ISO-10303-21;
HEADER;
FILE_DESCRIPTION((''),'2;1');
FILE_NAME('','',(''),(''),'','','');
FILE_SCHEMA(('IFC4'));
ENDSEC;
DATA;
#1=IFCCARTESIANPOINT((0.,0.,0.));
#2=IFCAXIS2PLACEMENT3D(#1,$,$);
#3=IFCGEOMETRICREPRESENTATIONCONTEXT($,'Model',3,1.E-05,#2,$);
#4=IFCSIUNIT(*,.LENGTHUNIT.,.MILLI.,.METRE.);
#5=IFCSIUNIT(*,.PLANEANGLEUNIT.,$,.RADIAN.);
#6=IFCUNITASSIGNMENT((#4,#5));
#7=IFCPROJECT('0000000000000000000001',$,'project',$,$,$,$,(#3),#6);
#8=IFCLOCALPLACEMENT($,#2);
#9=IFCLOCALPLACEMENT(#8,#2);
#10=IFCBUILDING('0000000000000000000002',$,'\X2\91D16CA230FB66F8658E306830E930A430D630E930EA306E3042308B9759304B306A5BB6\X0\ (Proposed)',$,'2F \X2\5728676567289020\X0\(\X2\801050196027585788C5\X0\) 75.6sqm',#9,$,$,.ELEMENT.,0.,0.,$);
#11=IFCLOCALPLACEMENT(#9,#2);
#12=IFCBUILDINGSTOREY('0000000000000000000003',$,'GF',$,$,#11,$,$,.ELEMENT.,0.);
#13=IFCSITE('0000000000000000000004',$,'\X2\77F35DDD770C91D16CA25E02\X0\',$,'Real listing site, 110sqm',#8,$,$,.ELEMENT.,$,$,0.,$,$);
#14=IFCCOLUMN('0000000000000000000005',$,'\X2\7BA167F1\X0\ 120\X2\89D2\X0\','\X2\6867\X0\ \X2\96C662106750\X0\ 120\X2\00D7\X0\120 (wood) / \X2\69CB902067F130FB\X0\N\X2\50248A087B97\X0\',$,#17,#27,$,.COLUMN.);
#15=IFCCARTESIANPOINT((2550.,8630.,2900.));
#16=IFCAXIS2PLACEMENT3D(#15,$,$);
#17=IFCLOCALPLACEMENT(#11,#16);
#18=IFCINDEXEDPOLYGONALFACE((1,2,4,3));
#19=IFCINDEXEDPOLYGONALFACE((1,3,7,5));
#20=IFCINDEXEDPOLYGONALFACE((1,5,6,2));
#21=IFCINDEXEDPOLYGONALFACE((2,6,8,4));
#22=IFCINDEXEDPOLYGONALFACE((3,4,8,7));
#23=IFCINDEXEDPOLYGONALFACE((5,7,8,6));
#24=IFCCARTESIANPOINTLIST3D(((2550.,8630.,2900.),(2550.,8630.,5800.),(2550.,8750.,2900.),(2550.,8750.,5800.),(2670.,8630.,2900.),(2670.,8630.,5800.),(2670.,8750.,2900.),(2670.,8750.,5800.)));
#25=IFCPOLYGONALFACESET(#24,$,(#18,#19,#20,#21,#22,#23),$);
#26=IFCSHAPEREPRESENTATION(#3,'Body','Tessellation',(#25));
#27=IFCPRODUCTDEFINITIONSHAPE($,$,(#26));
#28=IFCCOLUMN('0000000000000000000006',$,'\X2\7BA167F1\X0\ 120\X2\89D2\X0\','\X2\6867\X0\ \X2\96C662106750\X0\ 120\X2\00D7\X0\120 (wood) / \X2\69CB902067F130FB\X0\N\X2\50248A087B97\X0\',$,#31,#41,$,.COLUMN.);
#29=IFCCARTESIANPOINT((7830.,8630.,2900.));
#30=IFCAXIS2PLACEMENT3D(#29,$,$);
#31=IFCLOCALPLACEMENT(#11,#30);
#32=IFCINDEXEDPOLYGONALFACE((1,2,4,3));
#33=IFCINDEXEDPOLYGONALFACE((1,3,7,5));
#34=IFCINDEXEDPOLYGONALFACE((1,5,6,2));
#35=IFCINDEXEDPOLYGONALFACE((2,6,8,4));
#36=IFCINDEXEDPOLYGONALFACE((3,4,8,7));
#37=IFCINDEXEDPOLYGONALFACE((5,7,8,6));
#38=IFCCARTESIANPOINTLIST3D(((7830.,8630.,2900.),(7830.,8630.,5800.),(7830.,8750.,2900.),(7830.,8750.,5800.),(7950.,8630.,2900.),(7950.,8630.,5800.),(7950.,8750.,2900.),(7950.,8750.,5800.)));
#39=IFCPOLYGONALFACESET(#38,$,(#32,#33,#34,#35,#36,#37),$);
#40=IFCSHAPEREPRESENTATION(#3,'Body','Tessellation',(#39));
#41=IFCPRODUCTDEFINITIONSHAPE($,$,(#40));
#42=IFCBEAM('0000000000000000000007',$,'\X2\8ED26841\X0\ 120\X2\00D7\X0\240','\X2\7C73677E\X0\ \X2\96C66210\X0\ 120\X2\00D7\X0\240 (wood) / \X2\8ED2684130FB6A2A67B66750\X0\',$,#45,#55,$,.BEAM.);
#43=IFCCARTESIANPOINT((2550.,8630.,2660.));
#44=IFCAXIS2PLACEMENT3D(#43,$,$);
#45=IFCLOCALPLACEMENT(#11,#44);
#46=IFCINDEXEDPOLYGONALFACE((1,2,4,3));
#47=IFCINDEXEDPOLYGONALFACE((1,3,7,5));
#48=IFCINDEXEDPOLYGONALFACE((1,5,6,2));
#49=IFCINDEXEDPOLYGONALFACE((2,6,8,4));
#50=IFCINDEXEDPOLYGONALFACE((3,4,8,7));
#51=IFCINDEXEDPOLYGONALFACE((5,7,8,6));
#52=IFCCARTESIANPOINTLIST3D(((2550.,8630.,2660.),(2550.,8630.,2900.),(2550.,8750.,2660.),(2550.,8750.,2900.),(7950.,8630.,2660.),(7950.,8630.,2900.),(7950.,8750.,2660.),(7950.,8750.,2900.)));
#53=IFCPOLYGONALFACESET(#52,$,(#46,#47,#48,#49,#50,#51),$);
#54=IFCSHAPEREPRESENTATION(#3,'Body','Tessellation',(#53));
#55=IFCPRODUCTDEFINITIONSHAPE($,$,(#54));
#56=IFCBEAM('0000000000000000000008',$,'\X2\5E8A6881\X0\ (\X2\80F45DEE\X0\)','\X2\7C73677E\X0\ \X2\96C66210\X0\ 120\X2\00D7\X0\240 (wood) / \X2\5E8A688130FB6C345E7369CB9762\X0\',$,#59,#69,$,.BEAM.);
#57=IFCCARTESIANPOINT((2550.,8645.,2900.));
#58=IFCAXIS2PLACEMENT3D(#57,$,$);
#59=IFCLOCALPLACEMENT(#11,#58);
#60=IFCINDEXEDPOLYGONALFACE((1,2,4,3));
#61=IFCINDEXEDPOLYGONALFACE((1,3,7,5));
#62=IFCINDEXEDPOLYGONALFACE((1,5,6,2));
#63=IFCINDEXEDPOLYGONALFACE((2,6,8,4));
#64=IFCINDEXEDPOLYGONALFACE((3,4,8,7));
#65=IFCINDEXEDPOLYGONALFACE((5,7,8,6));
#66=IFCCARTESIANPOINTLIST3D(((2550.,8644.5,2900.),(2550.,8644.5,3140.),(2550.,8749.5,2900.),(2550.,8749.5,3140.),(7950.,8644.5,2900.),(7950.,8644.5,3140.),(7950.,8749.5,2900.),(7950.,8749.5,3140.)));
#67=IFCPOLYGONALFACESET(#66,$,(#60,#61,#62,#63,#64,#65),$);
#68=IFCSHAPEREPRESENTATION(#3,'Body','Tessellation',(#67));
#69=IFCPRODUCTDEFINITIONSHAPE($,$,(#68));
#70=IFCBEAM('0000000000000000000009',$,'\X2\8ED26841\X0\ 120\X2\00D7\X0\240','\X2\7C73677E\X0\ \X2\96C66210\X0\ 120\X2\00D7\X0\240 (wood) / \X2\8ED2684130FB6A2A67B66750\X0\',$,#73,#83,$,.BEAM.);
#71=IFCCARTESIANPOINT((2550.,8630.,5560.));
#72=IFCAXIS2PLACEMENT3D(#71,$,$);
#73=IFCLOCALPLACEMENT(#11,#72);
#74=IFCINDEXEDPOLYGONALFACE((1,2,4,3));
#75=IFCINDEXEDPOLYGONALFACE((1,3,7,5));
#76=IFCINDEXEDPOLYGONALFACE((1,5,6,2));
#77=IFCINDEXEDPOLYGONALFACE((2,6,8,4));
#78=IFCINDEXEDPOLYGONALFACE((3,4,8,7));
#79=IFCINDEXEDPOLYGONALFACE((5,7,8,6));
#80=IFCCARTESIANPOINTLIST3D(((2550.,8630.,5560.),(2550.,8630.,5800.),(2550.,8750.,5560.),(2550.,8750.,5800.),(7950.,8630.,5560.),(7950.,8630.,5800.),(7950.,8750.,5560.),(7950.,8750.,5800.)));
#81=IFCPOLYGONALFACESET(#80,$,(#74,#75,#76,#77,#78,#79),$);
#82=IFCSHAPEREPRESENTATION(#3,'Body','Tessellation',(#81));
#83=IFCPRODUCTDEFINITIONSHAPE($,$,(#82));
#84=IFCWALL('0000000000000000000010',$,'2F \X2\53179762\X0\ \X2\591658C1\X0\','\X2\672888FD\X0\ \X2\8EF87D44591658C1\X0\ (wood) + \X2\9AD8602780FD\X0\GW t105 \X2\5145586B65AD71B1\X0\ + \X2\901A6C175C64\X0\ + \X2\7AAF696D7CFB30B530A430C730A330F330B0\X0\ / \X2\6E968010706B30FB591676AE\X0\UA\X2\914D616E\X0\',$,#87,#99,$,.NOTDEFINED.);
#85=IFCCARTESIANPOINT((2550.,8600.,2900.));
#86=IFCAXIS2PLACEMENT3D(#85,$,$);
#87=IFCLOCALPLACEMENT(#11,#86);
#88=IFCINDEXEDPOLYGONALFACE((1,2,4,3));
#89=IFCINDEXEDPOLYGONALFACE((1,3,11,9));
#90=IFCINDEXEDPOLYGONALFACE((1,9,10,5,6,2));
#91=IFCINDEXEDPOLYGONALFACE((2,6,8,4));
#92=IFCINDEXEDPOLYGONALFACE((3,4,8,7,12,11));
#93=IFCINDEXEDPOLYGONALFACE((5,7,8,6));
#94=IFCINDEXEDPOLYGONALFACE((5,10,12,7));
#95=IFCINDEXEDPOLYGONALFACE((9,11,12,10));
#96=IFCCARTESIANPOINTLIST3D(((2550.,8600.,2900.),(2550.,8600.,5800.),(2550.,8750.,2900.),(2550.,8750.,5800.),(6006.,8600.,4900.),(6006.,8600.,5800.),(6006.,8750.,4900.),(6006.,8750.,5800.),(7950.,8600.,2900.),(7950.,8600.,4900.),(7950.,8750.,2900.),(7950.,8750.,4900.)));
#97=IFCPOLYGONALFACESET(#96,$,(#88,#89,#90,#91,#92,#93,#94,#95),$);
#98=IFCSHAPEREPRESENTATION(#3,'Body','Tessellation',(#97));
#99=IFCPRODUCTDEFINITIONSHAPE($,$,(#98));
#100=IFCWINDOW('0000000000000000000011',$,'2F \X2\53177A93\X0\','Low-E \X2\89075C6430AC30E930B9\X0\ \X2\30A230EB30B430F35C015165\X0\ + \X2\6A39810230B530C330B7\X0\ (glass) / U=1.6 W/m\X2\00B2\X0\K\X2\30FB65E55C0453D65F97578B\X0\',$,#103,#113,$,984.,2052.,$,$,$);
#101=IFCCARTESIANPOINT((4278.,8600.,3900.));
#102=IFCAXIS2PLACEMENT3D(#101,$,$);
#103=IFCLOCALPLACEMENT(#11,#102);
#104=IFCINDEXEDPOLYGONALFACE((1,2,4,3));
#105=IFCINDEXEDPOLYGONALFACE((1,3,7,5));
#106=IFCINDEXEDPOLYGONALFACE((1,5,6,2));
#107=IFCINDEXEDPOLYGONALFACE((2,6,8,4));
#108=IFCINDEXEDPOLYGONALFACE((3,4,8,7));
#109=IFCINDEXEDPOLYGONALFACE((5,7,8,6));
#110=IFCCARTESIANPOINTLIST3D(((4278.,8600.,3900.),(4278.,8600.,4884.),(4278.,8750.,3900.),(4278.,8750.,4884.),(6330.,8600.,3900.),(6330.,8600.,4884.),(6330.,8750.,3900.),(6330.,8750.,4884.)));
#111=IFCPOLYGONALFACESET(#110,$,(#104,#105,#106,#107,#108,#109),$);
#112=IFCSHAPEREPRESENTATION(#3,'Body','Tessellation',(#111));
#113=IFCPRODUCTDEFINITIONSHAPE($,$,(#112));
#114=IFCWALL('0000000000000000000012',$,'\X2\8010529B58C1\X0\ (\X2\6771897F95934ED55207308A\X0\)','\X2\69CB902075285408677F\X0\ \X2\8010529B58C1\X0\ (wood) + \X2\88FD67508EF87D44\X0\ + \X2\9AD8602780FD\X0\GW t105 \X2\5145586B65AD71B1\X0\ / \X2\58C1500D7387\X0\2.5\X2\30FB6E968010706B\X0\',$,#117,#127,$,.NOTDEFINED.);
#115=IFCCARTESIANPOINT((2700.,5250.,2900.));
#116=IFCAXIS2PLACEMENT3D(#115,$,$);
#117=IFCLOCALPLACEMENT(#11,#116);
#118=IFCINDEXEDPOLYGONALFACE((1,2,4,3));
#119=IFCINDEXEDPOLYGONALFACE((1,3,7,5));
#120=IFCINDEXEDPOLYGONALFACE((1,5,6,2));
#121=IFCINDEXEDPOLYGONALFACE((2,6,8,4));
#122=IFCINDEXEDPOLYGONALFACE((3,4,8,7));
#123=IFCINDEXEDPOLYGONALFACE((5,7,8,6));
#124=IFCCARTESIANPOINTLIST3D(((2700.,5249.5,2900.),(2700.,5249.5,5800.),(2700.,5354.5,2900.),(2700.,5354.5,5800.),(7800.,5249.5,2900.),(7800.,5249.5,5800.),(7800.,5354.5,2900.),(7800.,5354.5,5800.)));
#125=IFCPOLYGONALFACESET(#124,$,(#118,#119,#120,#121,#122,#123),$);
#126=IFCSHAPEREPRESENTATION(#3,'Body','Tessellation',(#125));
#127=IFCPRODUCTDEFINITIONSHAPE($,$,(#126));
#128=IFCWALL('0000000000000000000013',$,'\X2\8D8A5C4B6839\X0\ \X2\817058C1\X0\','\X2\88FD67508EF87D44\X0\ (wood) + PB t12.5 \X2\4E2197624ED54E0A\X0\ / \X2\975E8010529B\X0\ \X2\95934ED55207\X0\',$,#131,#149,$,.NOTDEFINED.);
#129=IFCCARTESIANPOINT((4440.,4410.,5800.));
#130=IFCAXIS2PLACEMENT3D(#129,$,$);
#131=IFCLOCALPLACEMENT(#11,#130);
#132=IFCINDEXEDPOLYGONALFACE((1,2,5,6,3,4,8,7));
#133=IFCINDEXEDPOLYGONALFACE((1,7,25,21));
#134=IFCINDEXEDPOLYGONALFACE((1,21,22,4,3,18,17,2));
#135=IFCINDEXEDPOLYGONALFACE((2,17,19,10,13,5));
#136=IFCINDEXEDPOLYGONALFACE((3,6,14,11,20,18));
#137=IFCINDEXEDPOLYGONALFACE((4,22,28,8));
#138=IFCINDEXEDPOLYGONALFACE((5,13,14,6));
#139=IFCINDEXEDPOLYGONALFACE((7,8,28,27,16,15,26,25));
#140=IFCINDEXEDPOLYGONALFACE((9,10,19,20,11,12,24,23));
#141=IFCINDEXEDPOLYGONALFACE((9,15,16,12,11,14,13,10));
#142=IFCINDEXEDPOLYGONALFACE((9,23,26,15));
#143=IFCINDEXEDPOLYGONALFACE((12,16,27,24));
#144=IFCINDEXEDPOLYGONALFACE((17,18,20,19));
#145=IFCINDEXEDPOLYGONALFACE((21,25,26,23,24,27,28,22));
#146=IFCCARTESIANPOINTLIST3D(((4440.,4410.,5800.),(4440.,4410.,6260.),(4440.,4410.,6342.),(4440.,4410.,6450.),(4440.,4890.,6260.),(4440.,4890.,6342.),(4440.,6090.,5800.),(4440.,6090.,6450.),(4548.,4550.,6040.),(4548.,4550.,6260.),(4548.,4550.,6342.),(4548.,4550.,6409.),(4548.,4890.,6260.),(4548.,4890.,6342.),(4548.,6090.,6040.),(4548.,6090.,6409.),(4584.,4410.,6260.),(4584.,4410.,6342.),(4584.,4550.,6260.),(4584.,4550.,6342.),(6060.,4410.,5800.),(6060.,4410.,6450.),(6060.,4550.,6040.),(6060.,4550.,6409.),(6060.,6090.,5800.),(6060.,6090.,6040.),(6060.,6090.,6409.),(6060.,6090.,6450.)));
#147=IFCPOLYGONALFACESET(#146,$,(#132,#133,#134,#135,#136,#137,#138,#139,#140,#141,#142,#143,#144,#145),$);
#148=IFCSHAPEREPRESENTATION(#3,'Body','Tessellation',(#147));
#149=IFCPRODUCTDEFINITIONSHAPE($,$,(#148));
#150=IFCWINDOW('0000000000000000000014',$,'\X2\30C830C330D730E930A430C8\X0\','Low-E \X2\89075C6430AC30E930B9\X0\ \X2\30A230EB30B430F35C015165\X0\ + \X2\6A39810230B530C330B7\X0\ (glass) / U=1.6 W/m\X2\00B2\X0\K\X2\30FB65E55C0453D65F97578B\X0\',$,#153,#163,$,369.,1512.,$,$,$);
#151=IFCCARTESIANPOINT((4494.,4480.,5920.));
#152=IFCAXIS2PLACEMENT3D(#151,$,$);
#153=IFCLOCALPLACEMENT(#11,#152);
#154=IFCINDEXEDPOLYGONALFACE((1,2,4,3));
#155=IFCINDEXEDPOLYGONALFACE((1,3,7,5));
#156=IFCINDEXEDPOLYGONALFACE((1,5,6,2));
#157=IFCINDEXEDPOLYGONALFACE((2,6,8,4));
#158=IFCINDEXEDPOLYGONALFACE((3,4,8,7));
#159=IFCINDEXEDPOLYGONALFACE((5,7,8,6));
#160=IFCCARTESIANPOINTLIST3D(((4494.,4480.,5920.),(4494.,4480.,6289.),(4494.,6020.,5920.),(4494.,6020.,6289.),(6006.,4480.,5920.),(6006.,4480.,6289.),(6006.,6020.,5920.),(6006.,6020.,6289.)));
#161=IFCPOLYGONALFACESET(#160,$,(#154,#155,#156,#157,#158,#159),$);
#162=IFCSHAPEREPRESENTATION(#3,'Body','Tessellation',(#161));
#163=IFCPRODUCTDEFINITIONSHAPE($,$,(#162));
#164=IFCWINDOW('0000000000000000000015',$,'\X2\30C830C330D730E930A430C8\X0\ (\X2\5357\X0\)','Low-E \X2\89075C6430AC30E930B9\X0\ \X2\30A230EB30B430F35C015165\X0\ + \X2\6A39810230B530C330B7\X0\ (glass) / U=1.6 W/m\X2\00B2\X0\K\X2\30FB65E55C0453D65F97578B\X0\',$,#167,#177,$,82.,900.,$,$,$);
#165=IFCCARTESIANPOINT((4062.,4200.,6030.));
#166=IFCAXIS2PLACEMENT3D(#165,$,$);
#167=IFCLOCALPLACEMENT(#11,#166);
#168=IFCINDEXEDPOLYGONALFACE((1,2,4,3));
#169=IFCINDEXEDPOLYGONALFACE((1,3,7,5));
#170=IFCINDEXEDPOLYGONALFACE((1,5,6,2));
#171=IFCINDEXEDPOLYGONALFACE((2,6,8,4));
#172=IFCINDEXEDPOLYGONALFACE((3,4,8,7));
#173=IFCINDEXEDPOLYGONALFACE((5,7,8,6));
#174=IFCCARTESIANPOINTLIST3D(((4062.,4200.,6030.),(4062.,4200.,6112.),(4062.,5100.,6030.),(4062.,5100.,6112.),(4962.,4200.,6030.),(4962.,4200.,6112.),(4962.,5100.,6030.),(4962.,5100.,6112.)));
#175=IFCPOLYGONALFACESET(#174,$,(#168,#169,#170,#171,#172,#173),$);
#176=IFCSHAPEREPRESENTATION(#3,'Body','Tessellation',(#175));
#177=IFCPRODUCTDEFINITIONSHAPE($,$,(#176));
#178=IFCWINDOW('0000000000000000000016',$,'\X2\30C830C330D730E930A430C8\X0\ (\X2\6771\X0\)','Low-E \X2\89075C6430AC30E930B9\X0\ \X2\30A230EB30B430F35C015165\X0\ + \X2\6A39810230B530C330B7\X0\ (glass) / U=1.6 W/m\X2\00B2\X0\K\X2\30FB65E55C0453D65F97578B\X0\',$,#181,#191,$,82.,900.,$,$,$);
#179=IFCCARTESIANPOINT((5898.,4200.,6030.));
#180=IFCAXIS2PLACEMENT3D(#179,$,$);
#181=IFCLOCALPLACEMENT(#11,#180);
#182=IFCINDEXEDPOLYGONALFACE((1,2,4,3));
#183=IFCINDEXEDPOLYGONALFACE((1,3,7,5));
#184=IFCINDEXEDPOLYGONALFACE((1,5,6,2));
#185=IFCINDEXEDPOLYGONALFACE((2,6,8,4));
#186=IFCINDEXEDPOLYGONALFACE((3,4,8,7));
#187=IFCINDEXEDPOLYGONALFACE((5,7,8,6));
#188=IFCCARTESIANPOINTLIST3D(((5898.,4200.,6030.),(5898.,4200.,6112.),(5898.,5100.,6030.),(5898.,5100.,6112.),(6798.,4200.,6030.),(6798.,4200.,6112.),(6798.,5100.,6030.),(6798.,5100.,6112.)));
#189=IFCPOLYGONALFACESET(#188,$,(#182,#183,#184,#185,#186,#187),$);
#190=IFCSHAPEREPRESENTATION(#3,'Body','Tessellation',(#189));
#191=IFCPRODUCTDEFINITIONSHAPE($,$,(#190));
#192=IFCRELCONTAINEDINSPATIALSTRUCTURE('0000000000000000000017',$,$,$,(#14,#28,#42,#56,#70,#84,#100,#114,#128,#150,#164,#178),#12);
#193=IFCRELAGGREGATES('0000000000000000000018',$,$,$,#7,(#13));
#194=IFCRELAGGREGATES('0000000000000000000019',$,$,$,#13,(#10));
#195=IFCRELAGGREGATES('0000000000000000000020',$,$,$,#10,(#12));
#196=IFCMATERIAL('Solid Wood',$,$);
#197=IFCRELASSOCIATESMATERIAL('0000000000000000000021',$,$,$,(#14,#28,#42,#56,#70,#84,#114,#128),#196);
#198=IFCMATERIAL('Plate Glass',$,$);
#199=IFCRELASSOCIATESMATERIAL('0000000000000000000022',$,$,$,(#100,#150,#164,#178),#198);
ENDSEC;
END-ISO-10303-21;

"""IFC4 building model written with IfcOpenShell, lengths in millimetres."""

from ifc_helpers import new_model, si_unit, frame, frame_2d, origin, place, context, project, spatial, rectangle, extrude, material, element, fill, save


model = new_model("IFC4")

# Units and contexts
model_context = context("Model", 3, precision=1e-05, world=origin())
ifc_project = project(units=[si_unit("LENGTHUNIT", "METRE", prefix="MILLI"), si_unit("PLANEANGLEUNIT", "RADIAN")], contexts=[model_context])

# Site, building, storey
site_placement = place(None, origin())
site = spatial("IfcSite", under=ifc_project, at=site_placement, Name="石川県金沢市", ObjectType="Real listing site, 110sqm", CompositionType="ELEMENT", RefElevation=0.0)
building_placement = place(site_placement, origin())
building = spatial("IfcBuilding", under=site, at=building_placement, Name="金沢・書斎とライブラリのある静かな家 (Proposed)", ObjectType="2F 在来木造(耐候性塗装) 75.6sqm", CompositionType="ELEMENT", ElevationOfRefHeight=0.0, ElevationOfTerrain=0.0)
storey_placement = place(building_placement, origin())
storey = spatial("IfcBuildingStorey", under=building, at=storey_placement, Name="GF", CompositionType="ELEMENT", Elevation=0.0)

# Columns
ifc_material_1 = material(Name="Solid Wood")
column_1_placement = place(storey_placement, frame((2550.0, 8630.0, 2900.0)))
element("IfcColumn", 1, at=column_1_placement, inside=storey, material=ifc_material_1, Name="管柱 120角", Description="桧 集成材 120×120 (wood) / 構造柱・N値計算", PredefinedType="COLUMN", context=model_context, shape_type="SweptSolid", body=[
    extrude(rectangle(XDim=120.0, YDim=120.0, at=frame_2d((60.0, 60.0))), frame((2550.0, 8630.0, 2900.0)), (0.0, 0.0, 1.0), 2900.0),
])
column_2_placement = place(storey_placement, frame((7830.0, 8630.0, 2900.0)))
element("IfcColumn", 2, at=column_2_placement, inside=storey, material=ifc_material_1, Name="管柱 120角", Description="桧 集成材 120×120 (wood) / 構造柱・N値計算", PredefinedType="COLUMN", context=model_context, shape_type="SweptSolid", body=[
    extrude(rectangle(XDim=120.0, YDim=120.0, at=frame_2d((60.0, 60.0))), frame((7830.0, 8630.0, 2900.0)), (0.0, 0.0, 1.0), 2900.0),
])

# Beams
beam_1_placement = place(storey_placement, frame((2550.0, 8630.0, 2660.0)))
element("IfcBeam", 3, at=beam_1_placement, inside=storey, material=ifc_material_1, Name="軒桁 120×240", Description="米松 集成 120×240 (wood) / 軒桁・横架材", PredefinedType="BEAM", context=model_context, shape_type="SweptSolid", body=[
    extrude(rectangle(XDim=5400.0, YDim=120.0, at=frame_2d((2700.0, 60.0))), frame((2550.0, 8630.0, 2660.0)), (0.0, 0.0, 1.0), 240.0),
])
beam_2_placement = place(storey_placement, frame((2550.0, 8645.0, 2900.0)))
element("IfcBeam", 4, at=beam_2_placement, inside=storey, material=ifc_material_1, Name="床梁 (胴差)", Description="米松 集成 120×240 (wood) / 床梁・水平構面", PredefinedType="BEAM", context=model_context, shape_type="SweptSolid", body=[
    extrude(rectangle(XDim=5400.0, YDim=105.0, at=frame_2d((2700.0, 52.0))), frame((2550.0, 8645.0, 2900.0)), (0.0, 0.0, 1.0), 240.0),
])
beam_3_placement = place(storey_placement, frame((2550.0, 8630.0, 5560.0)))
element("IfcBeam", 5, at=beam_3_placement, inside=storey, material=ifc_material_1, Name="軒桁 120×240", Description="米松 集成 120×240 (wood) / 軒桁・横架材", PredefinedType="BEAM", context=model_context, shape_type="SweptSolid", body=[
    extrude(rectangle(XDim=5400.0, YDim=120.0, at=frame_2d((2700.0, 60.0))), frame((2550.0, 8630.0, 5560.0)), (0.0, 0.0, 1.0), 240.0),
])

# Wall, opening, window
wall_1_placement = place(storey_placement, frame((2550.0, 8600.0, 2900.0)))
wall_1 = element("IfcWall", 6, at=wall_1_placement, inside=storey, material=ifc_material_1, Name="2F 北面 外壁", Description="木製 軸組外壁 (wood) + 高性能GW t105 充填断熱 + 通気層 + 窯業系サイディング / 準耐火・外皮UA配慮", PredefinedType="NOTDEFINED", context=model_context, shape_type="SweptSolid", body=[
    extrude(rectangle(XDim=5400.0, YDim=150.0, at=frame_2d((2700.0, 75.0))), frame((2550.0, 8600.0, 2900.0)), (0.0, 0.0, 1.0), 2900.0),
])
opening_1_placement = place(storey_placement, frame((4278.0, 8600.0, 3900.0)))
opening_1 = element("IfcOpeningElement", 7, at=opening_1_placement, cuts=wall_1, PredefinedType="NOTDEFINED", context=model_context, shape_type="SweptSolid", body=[
    extrude(rectangle(XDim=2052.0, YDim=150.0, at=frame_2d((1026.0, 75.0))), frame((4278.0, 8600.0, 3900.0)), (0.0, 0.0, 1.0), 984.0),
])
ifc_material_2 = material(Name="Plate Glass")
window_1_placement = place(storey_placement, frame((4278.0, 8600.0, 3900.0)))
window_1 = element("IfcWindow", 8, at=window_1_placement, inside=storey, material=ifc_material_2, Name="2F 北窓", Description="Low-E 複層ガラス アルゴン封入 + 樹脂サッシ (glass) / U=1.6 W/m²K・日射取得型", OverallHeight=984.0, OverallWidth=2052.0, context=model_context, shape_type="SweptSolid", body=[
    extrude(rectangle(XDim=2052.0, YDim=150.0, at=frame_2d((1026.0, 75.0))), frame((4278.0, 8600.0, 3900.0)), (0.0, 0.0, 1.0), 984.0),
])
fill(opening_1, window_1)

# Wall
wall_2_placement = place(storey_placement, frame((2700.0, 5250.0, 2900.0)))
element("IfcWall", 9, at=wall_2_placement, inside=storey, material=ifc_material_1, Name="耐力壁 (東西間仕切り)", Description="構造用合板 耐力壁 (wood) + 製材軸組 + 高性能GW t105 充填断熱 / 壁倍率2.5・準耐火", PredefinedType="NOTDEFINED", context=model_context, shape_type="SweptSolid", body=[
    extrude(rectangle(XDim=5100.0, YDim=105.0, at=frame_2d((2550.0, 52.0))), frame((2700.0, 5250.0, 2900.0)), (0.0, 0.0, 1.0), 2900.0),
])

# Wall, openings, windows
wall_3_placement = place(storey_placement, frame((4440.0, 4410.0, 5800.0)))
wall_3 = element("IfcWall", 10, at=wall_3_placement, inside=storey, material=ifc_material_1, Name="越屋根 腰壁", Description="製材軸組 (wood) + PB t12.5 両面仕上 / 非耐力 間仕切", PredefinedType="NOTDEFINED", context=model_context, shape_type="SweptSolid", body=[
    extrude(rectangle(XDim=1620.0, YDim=1680.0, at=frame_2d((810.0, 840.0))), frame((4440.0, 4410.0, 5800.0)), (0.0, 0.0, 1.0), 650.0),
])
opening_2_placement = place(storey_placement, frame((4494.0, 4480.0, 5920.0)))
opening_2 = element("IfcOpeningElement", 11, at=opening_2_placement, cuts=wall_3, PredefinedType="NOTDEFINED", context=model_context, shape_type="SweptSolid", body=[
    extrude(rectangle(XDim=1512.0, YDim=1540.0, at=frame_2d((756.0, 770.0))), frame((4494.0, 4480.0, 5920.0)), (0.0, 0.0, 1.0), 369.0),
])
opening_3_placement = place(storey_placement, frame((4062.0, 4200.0, 6030.0)))
opening_3 = element("IfcOpeningElement", 12, at=opening_3_placement, cuts=wall_3, PredefinedType="NOTDEFINED", context=model_context, shape_type="SweptSolid", body=[
    extrude(rectangle(XDim=900.0, YDim=900.0, at=frame_2d((450.0, 450.0))), frame((4062.0, 4200.0, 6030.0)), (0.0, 0.0, 1.0), 82.0),
])
opening_4_placement = place(storey_placement, frame((5898.0, 4200.0, 6030.0)))
opening_4 = element("IfcOpeningElement", 13, at=opening_4_placement, cuts=wall_3, PredefinedType="NOTDEFINED", context=model_context, shape_type="SweptSolid", body=[
    extrude(rectangle(XDim=900.0, YDim=900.0, at=frame_2d((450.0, 450.0))), frame((5898.0, 4200.0, 6030.0)), (0.0, 0.0, 1.0), 82.0),
])
window_2_placement = place(storey_placement, frame((4494.0, 4480.0, 5920.0)))
window_2 = element("IfcWindow", 14, at=window_2_placement, inside=storey, material=ifc_material_2, Name="トップライト", Description="Low-E 複層ガラス アルゴン封入 + 樹脂サッシ (glass) / U=1.6 W/m²K・日射取得型", OverallHeight=369.0, OverallWidth=1512.0, context=model_context, shape_type="SweptSolid", body=[
    extrude(rectangle(XDim=1512.0, YDim=1540.0, at=frame_2d((756.0, 770.0))), frame((4494.0, 4480.0, 5920.0)), (0.0, 0.0, 1.0), 369.0),
])
fill(opening_2, window_2)
window_3_placement = place(storey_placement, frame((4062.0, 4200.0, 6030.0)))
window_3 = element("IfcWindow", 15, at=window_3_placement, inside=storey, material=ifc_material_2, Name="トップライト (南)", Description="Low-E 複層ガラス アルゴン封入 + 樹脂サッシ (glass) / U=1.6 W/m²K・日射取得型", OverallHeight=82.0, OverallWidth=900.0, context=model_context, shape_type="SweptSolid", body=[
    extrude(rectangle(XDim=900.0, YDim=900.0, at=frame_2d((450.0, 450.0))), frame((4062.0, 4200.0, 6030.0)), (0.0, 0.0, 1.0), 82.0),
])
fill(opening_3, window_3)
window_4_placement = place(storey_placement, frame((5898.0, 4200.0, 6030.0)))
window_4 = element("IfcWindow", 16, at=window_4_placement, inside=storey, material=ifc_material_2, Name="トップライト (東)", Description="Low-E 複層ガラス アルゴン封入 + 樹脂サッシ (glass) / U=1.6 W/m²K・日射取得型", OverallHeight=82.0, OverallWidth=900.0, context=model_context, shape_type="SweptSolid", body=[
    extrude(rectangle(XDim=900.0, YDim=900.0, at=frame_2d((450.0, 450.0))), frame((5898.0, 4200.0, 6030.0)), (0.0, 0.0, 1.0), 82.0),
])
fill(opening_4, window_4)

save(model, "model.ifc")
